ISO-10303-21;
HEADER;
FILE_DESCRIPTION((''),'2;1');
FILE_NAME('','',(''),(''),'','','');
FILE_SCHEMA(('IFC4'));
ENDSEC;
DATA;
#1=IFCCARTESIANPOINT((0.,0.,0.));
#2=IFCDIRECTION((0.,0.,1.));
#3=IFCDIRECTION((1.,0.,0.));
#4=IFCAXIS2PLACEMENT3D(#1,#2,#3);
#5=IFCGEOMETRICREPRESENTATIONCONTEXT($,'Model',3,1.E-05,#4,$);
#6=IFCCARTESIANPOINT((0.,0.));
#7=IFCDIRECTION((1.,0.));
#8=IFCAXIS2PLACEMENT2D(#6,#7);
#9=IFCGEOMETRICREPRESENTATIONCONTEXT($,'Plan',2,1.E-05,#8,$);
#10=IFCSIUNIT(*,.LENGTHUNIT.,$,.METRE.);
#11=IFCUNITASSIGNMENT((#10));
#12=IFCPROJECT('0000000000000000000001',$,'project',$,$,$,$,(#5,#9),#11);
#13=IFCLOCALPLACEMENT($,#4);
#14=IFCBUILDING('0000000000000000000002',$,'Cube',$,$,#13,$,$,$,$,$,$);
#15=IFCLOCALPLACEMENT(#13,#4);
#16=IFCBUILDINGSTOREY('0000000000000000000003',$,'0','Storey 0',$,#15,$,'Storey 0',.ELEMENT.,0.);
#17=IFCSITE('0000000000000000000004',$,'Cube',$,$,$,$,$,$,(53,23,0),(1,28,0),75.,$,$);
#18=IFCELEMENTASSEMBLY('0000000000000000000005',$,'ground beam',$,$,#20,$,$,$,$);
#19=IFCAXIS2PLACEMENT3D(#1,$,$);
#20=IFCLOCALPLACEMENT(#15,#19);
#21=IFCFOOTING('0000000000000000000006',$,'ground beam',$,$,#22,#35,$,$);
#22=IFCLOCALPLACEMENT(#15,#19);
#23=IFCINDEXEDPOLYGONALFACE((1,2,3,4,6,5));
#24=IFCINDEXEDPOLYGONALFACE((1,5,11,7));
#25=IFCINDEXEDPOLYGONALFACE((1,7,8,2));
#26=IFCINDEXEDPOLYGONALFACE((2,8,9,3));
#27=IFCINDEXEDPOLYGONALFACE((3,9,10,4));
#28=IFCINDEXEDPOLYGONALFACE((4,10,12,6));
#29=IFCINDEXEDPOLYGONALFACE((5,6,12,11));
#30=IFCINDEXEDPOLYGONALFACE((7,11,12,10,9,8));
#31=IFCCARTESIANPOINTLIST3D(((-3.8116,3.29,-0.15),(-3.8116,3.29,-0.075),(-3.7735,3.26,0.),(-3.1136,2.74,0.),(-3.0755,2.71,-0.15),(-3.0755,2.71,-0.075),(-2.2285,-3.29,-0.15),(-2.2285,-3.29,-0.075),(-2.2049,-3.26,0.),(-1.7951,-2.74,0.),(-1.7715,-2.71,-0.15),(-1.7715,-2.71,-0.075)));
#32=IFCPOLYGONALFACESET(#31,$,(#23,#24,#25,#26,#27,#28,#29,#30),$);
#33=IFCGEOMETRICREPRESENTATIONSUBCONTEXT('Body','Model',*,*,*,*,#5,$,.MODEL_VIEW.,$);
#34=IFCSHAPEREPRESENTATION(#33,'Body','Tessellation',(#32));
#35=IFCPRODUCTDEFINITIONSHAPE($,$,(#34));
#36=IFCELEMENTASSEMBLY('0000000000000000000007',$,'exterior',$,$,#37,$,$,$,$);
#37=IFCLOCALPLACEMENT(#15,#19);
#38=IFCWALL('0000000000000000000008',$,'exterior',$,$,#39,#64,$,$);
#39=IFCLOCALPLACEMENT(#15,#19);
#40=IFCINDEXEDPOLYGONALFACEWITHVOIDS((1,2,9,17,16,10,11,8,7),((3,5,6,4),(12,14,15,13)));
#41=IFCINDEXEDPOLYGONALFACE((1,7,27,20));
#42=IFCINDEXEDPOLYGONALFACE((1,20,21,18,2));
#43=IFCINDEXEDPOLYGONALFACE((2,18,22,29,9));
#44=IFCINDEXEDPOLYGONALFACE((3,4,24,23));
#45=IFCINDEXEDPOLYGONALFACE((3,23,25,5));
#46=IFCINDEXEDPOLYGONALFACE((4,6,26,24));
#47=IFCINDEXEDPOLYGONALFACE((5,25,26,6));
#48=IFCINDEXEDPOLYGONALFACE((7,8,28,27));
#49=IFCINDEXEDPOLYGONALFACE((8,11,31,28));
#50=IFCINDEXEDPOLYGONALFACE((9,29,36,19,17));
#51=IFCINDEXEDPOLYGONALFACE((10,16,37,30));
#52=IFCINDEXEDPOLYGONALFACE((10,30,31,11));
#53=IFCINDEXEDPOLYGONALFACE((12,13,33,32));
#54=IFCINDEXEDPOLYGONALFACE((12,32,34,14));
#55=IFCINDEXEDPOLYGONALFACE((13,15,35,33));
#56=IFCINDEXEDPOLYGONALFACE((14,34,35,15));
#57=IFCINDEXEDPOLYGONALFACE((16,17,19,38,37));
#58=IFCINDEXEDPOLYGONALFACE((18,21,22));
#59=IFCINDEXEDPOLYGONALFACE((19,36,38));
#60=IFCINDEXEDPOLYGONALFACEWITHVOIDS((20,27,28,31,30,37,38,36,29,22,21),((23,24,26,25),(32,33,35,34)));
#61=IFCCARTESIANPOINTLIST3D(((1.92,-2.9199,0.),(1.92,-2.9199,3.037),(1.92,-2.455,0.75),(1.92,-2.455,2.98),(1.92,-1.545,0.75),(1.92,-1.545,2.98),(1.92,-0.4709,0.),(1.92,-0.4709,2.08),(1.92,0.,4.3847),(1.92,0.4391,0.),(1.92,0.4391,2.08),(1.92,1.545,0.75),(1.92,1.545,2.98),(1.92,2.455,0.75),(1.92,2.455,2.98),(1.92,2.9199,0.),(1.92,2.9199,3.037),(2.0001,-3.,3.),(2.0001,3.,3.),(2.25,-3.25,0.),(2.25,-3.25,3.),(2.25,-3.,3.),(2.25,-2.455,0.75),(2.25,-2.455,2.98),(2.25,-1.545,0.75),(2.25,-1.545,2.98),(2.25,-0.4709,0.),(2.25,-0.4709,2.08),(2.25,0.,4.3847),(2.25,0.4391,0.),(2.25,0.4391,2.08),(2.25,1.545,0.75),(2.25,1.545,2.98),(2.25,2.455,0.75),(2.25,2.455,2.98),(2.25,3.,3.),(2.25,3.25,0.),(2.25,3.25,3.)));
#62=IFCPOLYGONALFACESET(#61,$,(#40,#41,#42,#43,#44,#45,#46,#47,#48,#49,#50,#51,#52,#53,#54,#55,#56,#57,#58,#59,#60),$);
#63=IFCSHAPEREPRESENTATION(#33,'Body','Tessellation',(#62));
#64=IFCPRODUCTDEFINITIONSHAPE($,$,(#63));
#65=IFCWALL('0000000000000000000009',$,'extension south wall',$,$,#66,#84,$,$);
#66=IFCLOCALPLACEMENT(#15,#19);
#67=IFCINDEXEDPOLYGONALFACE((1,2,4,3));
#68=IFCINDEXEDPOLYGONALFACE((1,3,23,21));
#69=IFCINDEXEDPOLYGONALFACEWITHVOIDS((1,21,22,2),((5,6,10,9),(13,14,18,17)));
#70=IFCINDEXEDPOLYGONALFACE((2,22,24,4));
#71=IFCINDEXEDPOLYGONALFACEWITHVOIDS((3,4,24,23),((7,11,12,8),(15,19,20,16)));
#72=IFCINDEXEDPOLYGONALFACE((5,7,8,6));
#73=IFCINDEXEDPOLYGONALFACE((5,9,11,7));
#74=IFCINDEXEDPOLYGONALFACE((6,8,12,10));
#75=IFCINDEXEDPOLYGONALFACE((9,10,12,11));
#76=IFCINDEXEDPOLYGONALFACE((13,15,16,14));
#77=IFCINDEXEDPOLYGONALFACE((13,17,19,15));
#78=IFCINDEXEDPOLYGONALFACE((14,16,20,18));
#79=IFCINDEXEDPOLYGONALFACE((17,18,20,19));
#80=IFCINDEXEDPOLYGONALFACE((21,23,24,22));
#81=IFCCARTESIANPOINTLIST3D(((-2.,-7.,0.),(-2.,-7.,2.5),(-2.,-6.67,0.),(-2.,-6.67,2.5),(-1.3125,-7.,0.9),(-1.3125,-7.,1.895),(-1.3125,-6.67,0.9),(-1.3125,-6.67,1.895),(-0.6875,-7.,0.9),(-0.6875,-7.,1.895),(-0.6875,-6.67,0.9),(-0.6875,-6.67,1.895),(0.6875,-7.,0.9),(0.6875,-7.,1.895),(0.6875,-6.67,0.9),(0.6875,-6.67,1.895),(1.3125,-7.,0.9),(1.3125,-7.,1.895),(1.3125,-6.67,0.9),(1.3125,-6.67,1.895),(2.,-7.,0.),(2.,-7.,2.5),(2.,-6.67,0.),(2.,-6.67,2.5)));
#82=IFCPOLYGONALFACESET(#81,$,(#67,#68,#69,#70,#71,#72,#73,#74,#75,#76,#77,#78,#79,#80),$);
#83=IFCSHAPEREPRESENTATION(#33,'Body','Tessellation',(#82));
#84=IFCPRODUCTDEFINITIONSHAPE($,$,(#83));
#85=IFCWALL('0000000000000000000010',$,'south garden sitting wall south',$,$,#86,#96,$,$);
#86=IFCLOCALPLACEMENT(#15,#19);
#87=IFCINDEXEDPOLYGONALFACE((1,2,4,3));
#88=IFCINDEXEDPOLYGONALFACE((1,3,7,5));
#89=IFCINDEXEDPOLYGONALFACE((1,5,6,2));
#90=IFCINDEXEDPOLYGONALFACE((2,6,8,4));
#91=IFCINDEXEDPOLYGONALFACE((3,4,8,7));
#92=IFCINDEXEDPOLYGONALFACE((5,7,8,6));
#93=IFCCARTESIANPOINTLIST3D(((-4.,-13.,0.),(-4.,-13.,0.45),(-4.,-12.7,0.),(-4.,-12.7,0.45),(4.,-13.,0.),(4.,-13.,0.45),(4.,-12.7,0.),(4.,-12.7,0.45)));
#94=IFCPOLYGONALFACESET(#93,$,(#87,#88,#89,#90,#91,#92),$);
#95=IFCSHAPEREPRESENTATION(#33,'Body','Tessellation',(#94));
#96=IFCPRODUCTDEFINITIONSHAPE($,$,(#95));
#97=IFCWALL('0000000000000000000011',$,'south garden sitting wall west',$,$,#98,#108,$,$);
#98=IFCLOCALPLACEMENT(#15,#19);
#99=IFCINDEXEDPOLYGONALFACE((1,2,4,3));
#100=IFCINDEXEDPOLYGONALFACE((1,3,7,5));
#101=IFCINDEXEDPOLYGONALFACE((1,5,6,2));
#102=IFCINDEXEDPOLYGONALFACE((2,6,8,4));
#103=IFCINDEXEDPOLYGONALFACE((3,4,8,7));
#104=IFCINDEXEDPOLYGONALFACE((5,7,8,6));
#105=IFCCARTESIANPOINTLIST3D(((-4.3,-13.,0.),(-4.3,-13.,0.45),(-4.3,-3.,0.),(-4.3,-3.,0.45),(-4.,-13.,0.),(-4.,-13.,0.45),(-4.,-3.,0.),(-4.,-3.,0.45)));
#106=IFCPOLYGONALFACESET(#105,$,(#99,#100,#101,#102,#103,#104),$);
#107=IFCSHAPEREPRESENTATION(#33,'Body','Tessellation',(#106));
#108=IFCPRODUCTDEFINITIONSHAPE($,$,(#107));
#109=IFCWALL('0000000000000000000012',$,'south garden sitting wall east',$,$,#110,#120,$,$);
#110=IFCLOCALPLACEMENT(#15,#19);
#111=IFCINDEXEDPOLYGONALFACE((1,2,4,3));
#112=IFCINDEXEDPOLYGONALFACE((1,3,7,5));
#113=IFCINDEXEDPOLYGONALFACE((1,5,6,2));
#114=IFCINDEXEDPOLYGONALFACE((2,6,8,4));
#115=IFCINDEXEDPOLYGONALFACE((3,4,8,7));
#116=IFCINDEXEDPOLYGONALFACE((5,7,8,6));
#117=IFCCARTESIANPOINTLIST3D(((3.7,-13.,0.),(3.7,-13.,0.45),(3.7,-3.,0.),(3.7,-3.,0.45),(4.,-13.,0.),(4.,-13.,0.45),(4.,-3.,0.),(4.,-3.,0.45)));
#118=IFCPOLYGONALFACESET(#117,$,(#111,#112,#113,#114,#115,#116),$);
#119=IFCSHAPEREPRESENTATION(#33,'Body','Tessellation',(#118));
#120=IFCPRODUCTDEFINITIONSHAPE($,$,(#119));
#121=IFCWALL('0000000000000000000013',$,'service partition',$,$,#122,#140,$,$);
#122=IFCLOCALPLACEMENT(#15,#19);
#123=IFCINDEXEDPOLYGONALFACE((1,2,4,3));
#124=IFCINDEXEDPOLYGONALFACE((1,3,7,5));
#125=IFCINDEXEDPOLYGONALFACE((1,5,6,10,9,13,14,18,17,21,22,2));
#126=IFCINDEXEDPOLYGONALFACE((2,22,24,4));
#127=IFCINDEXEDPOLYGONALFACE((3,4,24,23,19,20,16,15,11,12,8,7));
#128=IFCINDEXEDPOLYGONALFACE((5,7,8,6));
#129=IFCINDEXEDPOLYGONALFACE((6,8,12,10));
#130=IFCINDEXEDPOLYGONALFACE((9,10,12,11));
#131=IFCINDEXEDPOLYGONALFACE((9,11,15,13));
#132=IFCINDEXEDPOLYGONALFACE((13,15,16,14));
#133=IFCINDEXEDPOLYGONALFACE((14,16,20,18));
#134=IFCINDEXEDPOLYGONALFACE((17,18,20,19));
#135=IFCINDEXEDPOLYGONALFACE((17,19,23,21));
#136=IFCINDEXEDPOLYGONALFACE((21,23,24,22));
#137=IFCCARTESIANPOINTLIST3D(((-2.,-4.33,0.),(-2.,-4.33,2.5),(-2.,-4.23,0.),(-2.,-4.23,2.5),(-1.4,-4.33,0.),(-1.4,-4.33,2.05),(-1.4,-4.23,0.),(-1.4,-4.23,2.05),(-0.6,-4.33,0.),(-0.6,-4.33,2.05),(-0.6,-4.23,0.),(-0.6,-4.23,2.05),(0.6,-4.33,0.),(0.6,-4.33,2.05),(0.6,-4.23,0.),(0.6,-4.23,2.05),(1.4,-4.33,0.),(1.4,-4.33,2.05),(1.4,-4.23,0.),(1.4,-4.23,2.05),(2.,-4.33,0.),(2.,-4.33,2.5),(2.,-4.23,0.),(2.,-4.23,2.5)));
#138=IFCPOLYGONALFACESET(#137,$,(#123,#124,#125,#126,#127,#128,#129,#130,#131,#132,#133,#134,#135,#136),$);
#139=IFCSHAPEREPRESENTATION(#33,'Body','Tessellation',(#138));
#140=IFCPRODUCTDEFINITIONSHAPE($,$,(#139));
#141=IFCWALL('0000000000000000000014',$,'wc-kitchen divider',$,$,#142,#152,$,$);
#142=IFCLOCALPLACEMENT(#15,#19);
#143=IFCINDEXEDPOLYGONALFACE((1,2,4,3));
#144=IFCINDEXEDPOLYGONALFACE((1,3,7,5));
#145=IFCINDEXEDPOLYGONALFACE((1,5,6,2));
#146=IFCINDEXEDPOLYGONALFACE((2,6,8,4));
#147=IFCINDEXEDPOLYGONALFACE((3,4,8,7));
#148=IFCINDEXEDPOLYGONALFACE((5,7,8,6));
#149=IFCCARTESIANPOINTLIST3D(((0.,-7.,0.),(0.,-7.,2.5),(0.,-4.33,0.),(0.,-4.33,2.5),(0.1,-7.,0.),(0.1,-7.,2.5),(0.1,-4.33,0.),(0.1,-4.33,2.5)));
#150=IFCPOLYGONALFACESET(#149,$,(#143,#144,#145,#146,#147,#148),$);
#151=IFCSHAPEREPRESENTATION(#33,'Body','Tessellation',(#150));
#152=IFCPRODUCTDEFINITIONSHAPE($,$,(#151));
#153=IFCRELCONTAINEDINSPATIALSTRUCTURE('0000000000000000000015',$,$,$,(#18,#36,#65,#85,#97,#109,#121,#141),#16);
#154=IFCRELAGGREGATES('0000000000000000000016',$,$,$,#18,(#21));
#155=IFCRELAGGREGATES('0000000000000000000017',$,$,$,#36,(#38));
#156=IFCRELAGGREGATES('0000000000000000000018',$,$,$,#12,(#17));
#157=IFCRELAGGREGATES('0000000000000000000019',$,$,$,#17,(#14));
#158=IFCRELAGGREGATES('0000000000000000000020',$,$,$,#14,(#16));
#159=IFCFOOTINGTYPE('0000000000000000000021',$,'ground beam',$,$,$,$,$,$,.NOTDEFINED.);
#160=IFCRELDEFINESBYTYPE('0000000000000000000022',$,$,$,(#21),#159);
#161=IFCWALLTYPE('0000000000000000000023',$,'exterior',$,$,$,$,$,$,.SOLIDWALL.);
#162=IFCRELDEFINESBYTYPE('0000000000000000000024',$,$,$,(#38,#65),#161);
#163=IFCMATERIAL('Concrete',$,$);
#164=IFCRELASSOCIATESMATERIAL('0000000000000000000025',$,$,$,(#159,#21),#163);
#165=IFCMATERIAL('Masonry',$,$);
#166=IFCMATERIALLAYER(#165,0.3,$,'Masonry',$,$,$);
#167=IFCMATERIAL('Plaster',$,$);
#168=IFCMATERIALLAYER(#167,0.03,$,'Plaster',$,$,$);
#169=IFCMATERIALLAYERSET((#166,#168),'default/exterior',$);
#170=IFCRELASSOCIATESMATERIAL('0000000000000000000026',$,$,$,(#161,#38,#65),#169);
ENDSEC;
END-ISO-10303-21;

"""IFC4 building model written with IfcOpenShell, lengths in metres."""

from ifc_helpers import new_model, si_unit, frame, origin, origin_with_axes, origin_2d_with_axis, place, context, subcontext, project, spatial, polyline, line, indexed_curve, outline, extrude, clip, halfspace, bounded_halfspace, source, transform, mapped, material, layer, layer_set, layer_usage, material_profile, profile_set, profile_usage, type_object, element, aggregate, save


model = new_model("IFC4")

# Units and contexts
model_context = context("Model", 3, precision=1e-05, world=origin_with_axes())
plan_context = context("Plan", 2, precision=1e-05, world=origin_2d_with_axis())
body_context_1 = subcontext(model_context, "Body", "Model", "MODEL_VIEW")
ifc_project = project(units=[si_unit("LENGTHUNIT", "METRE")], contexts=[model_context, plan_context])

# Site, building, storey
site = spatial("IfcSite", under=ifc_project, Name="Cube", RefLatitude=(53, 23, 0), RefLongitude=(1, 28, 0), RefElevation=75.0)
building_placement = place(None, origin_with_axes())
building = spatial("IfcBuilding", under=site, at=building_placement, Name="Cube")
storey_placement = place(building_placement, origin_with_axes())
storey = spatial("IfcBuildingStorey", under=building, at=storey_placement, Name="0", Description="Storey 0", LongName="Storey 0", CompositionType="ELEMENT", Elevation=0.0)

# Element assembly, footing
assembly_1_placement = place(storey_placement, origin_with_axes())
assembly_1 = element("IfcElementAssembly", 1, at=assembly_1_placement, inside=storey, Name="ground beam")
ifc_material_1 = material(Name="Concrete")
ifc_material_profile = material_profile(ifc_material_1, outline(polyline([(-0.26, 0.0), (-0.29, -0.075), (-0.29, -0.15), (0.29, -0.15), (0.29, -0.075), (0.26, 0.0), (-0.26, 0.0)])))
ifc_profile_set = profile_set([ifc_material_profile])
ifc_profile_usage = profile_usage(ifc_profile_set)
footing_type = type_object("IfcFootingType", Name="ground beam", PredefinedType="NOTDEFINED", material=ifc_profile_set)
footing_placement = place(assembly_1_placement, frame((-1.7661, -3.9723, 0.0), z_axis=(-0.233915, 0.972257, 0.0), x_axis=(-0.972257, -0.233915, 0.0)))
footing = element("IfcFooting", 2, at=footing_placement, type_object=footing_type, material=ifc_profile_usage, Name="ground beam", context=body_context_1, shape_type="Clipping", body=[
    clip(clip(extrude(outline(polyline([(-0.26, 0.0), (-0.29, -0.075), (-0.29, -0.15), (0.29, -0.15), (0.29, -0.075), (0.26, 0.0), (-0.26, 0.0)])), origin_with_axes(), (0.0, 0.0, 1.0), 8.1712), halfspace(frame((0.0, 0.0, 1.0), z_axis=(-0.618904, 0.0, -0.785467), x_axis=(0.0, 1.0, 0.0)), False)), halfspace(frame((0.0, 0.0, 7.1712), z_axis=(-0.785467, 0.0, 0.618904), x_axis=(0.0, 1.0, 0.0)), False)),
])
aggregate(assembly_1, [footing])

# Element assembly, wall, openings
assembly_2_placement = place(storey_placement, frame((2.0, -3.0, 0.0), z_axis=(0.0, 0.0, 1.0), x_axis=(0.0, 1.0, 0.0)))
assembly_2 = element("IfcElementAssembly", 3, at=assembly_2_placement, inside=storey, Name="exterior")
ifc_material_2 = material(Name="Masonry")
ifc_layer_1 = layer(ifc_material_2, 0.3, Name="Masonry")
ifc_material_3 = material(Name="Plaster")
ifc_layer_2 = layer(ifc_material_3, 0.03, Name="Plaster")
ifc_layer_set = layer_set([ifc_layer_1, ifc_layer_2], Name="default/exterior")
ifc_layer_usage_1 = layer_usage(ifc_layer_set, "AXIS2", "POSITIVE", -0.25)
wall_type = type_object("IfcWallType", Name="exterior", PredefinedType="SOLIDWALL", material=ifc_layer_set)
wall_1_placement = place(assembly_2_placement, origin_with_axes())
wall_1 = element("IfcWall", 4, at=wall_1_placement, type_object=wall_type, material=ifc_layer_usage_1, Name="exterior", context=body_context_1, shape_type="Clipping", body=[
    clip(clip(clip(clip(extrude(outline(polyline([(0.0801, 0.08), (-0.25, -0.25), (6.25, -0.25), (5.9199, 0.08), (0.0801, 0.08)])), origin(), (0.0, 0.0, 1.0), 4.385), bounded_halfspace(frame((6.0, 0.0, 3.0), z_axis=(0.419069, 0.0, 0.907954), x_axis=(0.0, -1.0, 0.0)), False, origin(), polyline([(6.0, -1.0), (3.0, -1.0), (3.0, 1.0), (6.0, 1.0), (6.0, -1.0)]))), bounded_halfspace(frame((6.0, 0.0, 3.0), z_axis=(0.0, 0.0, 1.0), x_axis=(0.0, 1.0, 0.0)), False, origin(), polyline([(6.0, 1.0), (7.0, 1.0), (7.0, -1.0), (6.0, -1.0), (6.0, 1.0)]))), bounded_halfspace(frame((3.0, 0.0, 4.3847), z_axis=(-0.419069, 0.0, 0.907954), x_axis=(0.0, -1.0, 0.0)), False, origin(), polyline([(3.0, -1.0), (0.0, -1.0), (0.0, 1.0), (3.0, 1.0), (3.0, -1.0)]))), bounded_halfspace(frame((0.0, 0.0, 3.0), z_axis=(0.0, 0.0, 1.0), x_axis=(0.0, -1.0, 0.0)), False, origin(), polyline([(0.0, -1.0), (-1.0, -1.0), (-1.0, 1.0), (0.0, 1.0), (0.0, -1.0)]))),
])
opening_1_placement = place(wall_1_placement, frame((0.545, -0.25, 0.75), z_axis=(0.0, 0.0, 1.0), x_axis=(1.0, 0.0, 0.0)))
element("IfcOpeningElement", 5, at=opening_1_placement, cuts=wall_1, PredefinedType="OPENING", context=body_context_1, shape_type="SweptSolid", body=[
    extrude(outline(polyline([(0.0, -0.02), (0.91, -0.02), (0.91, 0.35), (0.0, 0.35), (0.0, -0.02)])), origin(), (0.0, 0.0, 1.0), 2.23),
])
opening_2_placement = place(wall_1_placement, frame((4.545, -0.25, 0.75), z_axis=(0.0, 0.0, 1.0), x_axis=(1.0, 0.0, 0.0)))
element("IfcOpeningElement", 6, at=opening_2_placement, cuts=wall_1, PredefinedType="OPENING", context=body_context_1, shape_type="SweptSolid", body=[
    extrude(outline(polyline([(0.0, -0.02), (0.91, -0.02), (0.91, 0.35), (0.0, 0.35), (0.0, -0.02)])), origin(), (0.0, 0.0, 1.0), 2.23),
])
shared_shape_1 = source(origin_with_axes(), body_context_1, "Body", "SweptSolid", [
    extrude(outline(indexed_curve([(0.0, 0.0), (0.91, 0.0), (0.91, 2.08), (0.0, 2.08)], segments=[line(1, 2, 3, 4, 1)])), frame((0.0, -0.6, 0.0), z_axis=(0.0, -1.0, 0.0), x_axis=(1.0, 0.0, 0.0)), (0.0, 0.0, -1.0), 1.2),
])
opening_3_placement = place(wall_1_placement, frame((2.5291, -0.25, 0.0), z_axis=(0.0, 0.0, 1.0), x_axis=(1.0, 0.0, 0.0)))
element("IfcOpeningElement", 7, at=opening_3_placement, cuts=wall_1, PredefinedType="OPENING", context=body_context_1, shape_type="MappedRepresentation", body=[
    mapped(shared_shape_1, transform((0.0, 0.0, 0.0), x_axis=(1.0, 0.0, 0.0), y_axis=(0.0, 1.0, 0.0), z_axis=(0.0, 0.0, 1.0), scale=1.0)),
])
aggregate(assembly_2, [wall_1])

# Wall, openings
ifc_layer_usage_2 = layer_usage(ifc_layer_set, "AXIS2", "POSITIVE", 0.0)
wall_2_placement = place(storey_placement, frame((-2.0, -7.0, 0.0), z_axis=(0.0, 0.0, 1.0), x_axis=(1.0, 0.0, 0.0)))
wall_2 = element("IfcWall", 8, at=wall_2_placement, inside=storey, type_object=wall_type, material=ifc_layer_usage_2, Name="extension south wall", context=body_context_1, shape_type="SweptSolid", body=[
    extrude(outline(indexed_curve([(0.0, 0.0), (0.0, 0.33), (4.0, 0.33), (4.0, 0.0), (0.0, 0.0)], self_intersect=False)), origin_with_axes(), (0.0, 0.0, 1.0), 2.5),
])
opening_4_placement = place(wall_2_placement, frame((0.6875, 0.0, 0.9), z_axis=(0.0, 0.0, 1.0), x_axis=(1.0, 0.0, 0.0)))
element("IfcOpeningElement", 9, at=opening_4_placement, cuts=wall_2, PredefinedType="OPENING", context=body_context_1, shape_type="SweptSolid", body=[
    extrude(outline(indexed_curve([(0.0, 0.0), (0.0, 0.5), (0.625, 0.5), (0.625, 0.0), (0.0, 0.0)], self_intersect=False)), origin_with_axes(), (0.0, 0.0, 1.0), 0.995),
])
opening_5_placement = place(wall_2_placement, frame((2.6875, 0.0, 0.9), z_axis=(0.0, 0.0, 1.0), x_axis=(1.0, 0.0, 0.0)))
element("IfcOpeningElement", 10, at=opening_5_placement, cuts=wall_2, PredefinedType="OPENING", context=body_context_1, shape_type="SweptSolid", body=[
    extrude(outline(indexed_curve([(0.0, 0.0), (0.0, 0.5), (0.625, 0.5), (0.625, 0.0), (0.0, 0.0)], self_intersect=False)), origin_with_axes(), (0.0, 0.0, 1.0), 0.995),
])

# Walls
wall_3_placement = place(storey_placement, frame((-4.0, -13.0, 0.0), z_axis=(0.0, 0.0, 1.0), x_axis=(1.0, 0.0, 0.0)))
element("IfcWall", 11, at=wall_3_placement, inside=storey, Name="south garden sitting wall south", context=body_context_1, shape_type="SweptSolid", body=[
    extrude(outline(indexed_curve([(0.0, 0.0), (0.0, 0.3), (8.0, 0.3), (8.0, 0.0), (0.0, 0.0)], self_intersect=False)), origin_with_axes(), (0.0, 0.0, 1.0), 0.45),
])
for number, where, z_axis, x_axis, name in (
    (12, (-4.0, -13.0, 0.0), (0.0, 0.0, 1.0), (0.0, 1.0, 0.0), "south garden sitting wall west"),
    (13, (4.0, -13.0, 0.0), (0.0, 0.0, 1.0), (0.0, 1.0, 0.0), "south garden sitting wall east"),
):
    element("IfcWall", number, at=place(storey_placement, frame(where, z_axis=z_axis, x_axis=x_axis)), inside=storey, Name=name, context=body_context_1, shape_type="SweptSolid", body=[
        extrude(outline(indexed_curve([(0.0, 0.0), (0.0, 0.3), (10.0, 0.3), (10.0, 0.0), (0.0, 0.0)], self_intersect=False)), origin_with_axes(), (0.0, 0.0, 1.0), 0.45),
    ])

# Wall, openings
wall_4_placement = place(storey_placement, frame((-2.0, -4.33, 0.0), z_axis=(0.0, 0.0, 1.0), x_axis=(1.0, 0.0, 0.0)))
wall_4 = element("IfcWall", 14, at=wall_4_placement, inside=storey, Name="service partition", context=body_context_1, shape_type="SweptSolid", body=[
    extrude(outline(indexed_curve([(0.0, 0.0), (0.0, 0.1), (4.0, 0.1), (4.0, 0.0), (0.0, 0.0)], self_intersect=False)), origin_with_axes(), (0.0, 0.0, 1.0), 2.5),
])
opening_6_placement = place(wall_4_placement, frame((0.6, -0.05, 0.0), z_axis=(0.0, 0.0, 1.0), x_axis=(1.0, 0.0, 0.0)))
element("IfcOpeningElement", 15, at=opening_6_placement, cuts=wall_4, context=body_context_1, shape_type="SweptSolid", body=[
    extrude(outline(indexed_curve([(0.0, 0.0), (0.0, 0.3), (0.8, 0.3), (0.8, 0.0), (0.0, 0.0)], self_intersect=False)), origin_with_axes(), (0.0, 0.0, 1.0), 2.05),
])
opening_7_placement = place(wall_4_placement, frame((2.6, -0.05, 0.0), z_axis=(0.0, 0.0, 1.0), x_axis=(1.0, 0.0, 0.0)))
element("IfcOpeningElement", 16, at=opening_7_placement, cuts=wall_4, context=body_context_1, shape_type="SweptSolid", body=[
    extrude(outline(indexed_curve([(0.0, 0.0), (0.0, 0.3), (0.8, 0.3), (0.8, 0.0), (0.0, 0.0)], self_intersect=False)), origin_with_axes(), (0.0, 0.0, 1.0), 2.05),
])

# Wall
wall_5_placement = place(storey_placement, frame((0.0, -4.33, 0.0), z_axis=(0.0, 0.0, 1.0), x_axis=(0.0, -1.0, 0.0)))
element("IfcWall", 17, at=wall_5_placement, inside=storey, Name="wc-kitchen divider", context=body_context_1, shape_type="SweptSolid", body=[
    extrude(outline(indexed_curve([(0.0, 0.0), (0.0, 0.1), (2.67, 0.1), (2.67, 0.0), (0.0, 0.0)], self_intersect=False)), origin_with_axes(), (0.0, 0.0, 1.0), 2.5),
])

save(model, "model.ifc")
